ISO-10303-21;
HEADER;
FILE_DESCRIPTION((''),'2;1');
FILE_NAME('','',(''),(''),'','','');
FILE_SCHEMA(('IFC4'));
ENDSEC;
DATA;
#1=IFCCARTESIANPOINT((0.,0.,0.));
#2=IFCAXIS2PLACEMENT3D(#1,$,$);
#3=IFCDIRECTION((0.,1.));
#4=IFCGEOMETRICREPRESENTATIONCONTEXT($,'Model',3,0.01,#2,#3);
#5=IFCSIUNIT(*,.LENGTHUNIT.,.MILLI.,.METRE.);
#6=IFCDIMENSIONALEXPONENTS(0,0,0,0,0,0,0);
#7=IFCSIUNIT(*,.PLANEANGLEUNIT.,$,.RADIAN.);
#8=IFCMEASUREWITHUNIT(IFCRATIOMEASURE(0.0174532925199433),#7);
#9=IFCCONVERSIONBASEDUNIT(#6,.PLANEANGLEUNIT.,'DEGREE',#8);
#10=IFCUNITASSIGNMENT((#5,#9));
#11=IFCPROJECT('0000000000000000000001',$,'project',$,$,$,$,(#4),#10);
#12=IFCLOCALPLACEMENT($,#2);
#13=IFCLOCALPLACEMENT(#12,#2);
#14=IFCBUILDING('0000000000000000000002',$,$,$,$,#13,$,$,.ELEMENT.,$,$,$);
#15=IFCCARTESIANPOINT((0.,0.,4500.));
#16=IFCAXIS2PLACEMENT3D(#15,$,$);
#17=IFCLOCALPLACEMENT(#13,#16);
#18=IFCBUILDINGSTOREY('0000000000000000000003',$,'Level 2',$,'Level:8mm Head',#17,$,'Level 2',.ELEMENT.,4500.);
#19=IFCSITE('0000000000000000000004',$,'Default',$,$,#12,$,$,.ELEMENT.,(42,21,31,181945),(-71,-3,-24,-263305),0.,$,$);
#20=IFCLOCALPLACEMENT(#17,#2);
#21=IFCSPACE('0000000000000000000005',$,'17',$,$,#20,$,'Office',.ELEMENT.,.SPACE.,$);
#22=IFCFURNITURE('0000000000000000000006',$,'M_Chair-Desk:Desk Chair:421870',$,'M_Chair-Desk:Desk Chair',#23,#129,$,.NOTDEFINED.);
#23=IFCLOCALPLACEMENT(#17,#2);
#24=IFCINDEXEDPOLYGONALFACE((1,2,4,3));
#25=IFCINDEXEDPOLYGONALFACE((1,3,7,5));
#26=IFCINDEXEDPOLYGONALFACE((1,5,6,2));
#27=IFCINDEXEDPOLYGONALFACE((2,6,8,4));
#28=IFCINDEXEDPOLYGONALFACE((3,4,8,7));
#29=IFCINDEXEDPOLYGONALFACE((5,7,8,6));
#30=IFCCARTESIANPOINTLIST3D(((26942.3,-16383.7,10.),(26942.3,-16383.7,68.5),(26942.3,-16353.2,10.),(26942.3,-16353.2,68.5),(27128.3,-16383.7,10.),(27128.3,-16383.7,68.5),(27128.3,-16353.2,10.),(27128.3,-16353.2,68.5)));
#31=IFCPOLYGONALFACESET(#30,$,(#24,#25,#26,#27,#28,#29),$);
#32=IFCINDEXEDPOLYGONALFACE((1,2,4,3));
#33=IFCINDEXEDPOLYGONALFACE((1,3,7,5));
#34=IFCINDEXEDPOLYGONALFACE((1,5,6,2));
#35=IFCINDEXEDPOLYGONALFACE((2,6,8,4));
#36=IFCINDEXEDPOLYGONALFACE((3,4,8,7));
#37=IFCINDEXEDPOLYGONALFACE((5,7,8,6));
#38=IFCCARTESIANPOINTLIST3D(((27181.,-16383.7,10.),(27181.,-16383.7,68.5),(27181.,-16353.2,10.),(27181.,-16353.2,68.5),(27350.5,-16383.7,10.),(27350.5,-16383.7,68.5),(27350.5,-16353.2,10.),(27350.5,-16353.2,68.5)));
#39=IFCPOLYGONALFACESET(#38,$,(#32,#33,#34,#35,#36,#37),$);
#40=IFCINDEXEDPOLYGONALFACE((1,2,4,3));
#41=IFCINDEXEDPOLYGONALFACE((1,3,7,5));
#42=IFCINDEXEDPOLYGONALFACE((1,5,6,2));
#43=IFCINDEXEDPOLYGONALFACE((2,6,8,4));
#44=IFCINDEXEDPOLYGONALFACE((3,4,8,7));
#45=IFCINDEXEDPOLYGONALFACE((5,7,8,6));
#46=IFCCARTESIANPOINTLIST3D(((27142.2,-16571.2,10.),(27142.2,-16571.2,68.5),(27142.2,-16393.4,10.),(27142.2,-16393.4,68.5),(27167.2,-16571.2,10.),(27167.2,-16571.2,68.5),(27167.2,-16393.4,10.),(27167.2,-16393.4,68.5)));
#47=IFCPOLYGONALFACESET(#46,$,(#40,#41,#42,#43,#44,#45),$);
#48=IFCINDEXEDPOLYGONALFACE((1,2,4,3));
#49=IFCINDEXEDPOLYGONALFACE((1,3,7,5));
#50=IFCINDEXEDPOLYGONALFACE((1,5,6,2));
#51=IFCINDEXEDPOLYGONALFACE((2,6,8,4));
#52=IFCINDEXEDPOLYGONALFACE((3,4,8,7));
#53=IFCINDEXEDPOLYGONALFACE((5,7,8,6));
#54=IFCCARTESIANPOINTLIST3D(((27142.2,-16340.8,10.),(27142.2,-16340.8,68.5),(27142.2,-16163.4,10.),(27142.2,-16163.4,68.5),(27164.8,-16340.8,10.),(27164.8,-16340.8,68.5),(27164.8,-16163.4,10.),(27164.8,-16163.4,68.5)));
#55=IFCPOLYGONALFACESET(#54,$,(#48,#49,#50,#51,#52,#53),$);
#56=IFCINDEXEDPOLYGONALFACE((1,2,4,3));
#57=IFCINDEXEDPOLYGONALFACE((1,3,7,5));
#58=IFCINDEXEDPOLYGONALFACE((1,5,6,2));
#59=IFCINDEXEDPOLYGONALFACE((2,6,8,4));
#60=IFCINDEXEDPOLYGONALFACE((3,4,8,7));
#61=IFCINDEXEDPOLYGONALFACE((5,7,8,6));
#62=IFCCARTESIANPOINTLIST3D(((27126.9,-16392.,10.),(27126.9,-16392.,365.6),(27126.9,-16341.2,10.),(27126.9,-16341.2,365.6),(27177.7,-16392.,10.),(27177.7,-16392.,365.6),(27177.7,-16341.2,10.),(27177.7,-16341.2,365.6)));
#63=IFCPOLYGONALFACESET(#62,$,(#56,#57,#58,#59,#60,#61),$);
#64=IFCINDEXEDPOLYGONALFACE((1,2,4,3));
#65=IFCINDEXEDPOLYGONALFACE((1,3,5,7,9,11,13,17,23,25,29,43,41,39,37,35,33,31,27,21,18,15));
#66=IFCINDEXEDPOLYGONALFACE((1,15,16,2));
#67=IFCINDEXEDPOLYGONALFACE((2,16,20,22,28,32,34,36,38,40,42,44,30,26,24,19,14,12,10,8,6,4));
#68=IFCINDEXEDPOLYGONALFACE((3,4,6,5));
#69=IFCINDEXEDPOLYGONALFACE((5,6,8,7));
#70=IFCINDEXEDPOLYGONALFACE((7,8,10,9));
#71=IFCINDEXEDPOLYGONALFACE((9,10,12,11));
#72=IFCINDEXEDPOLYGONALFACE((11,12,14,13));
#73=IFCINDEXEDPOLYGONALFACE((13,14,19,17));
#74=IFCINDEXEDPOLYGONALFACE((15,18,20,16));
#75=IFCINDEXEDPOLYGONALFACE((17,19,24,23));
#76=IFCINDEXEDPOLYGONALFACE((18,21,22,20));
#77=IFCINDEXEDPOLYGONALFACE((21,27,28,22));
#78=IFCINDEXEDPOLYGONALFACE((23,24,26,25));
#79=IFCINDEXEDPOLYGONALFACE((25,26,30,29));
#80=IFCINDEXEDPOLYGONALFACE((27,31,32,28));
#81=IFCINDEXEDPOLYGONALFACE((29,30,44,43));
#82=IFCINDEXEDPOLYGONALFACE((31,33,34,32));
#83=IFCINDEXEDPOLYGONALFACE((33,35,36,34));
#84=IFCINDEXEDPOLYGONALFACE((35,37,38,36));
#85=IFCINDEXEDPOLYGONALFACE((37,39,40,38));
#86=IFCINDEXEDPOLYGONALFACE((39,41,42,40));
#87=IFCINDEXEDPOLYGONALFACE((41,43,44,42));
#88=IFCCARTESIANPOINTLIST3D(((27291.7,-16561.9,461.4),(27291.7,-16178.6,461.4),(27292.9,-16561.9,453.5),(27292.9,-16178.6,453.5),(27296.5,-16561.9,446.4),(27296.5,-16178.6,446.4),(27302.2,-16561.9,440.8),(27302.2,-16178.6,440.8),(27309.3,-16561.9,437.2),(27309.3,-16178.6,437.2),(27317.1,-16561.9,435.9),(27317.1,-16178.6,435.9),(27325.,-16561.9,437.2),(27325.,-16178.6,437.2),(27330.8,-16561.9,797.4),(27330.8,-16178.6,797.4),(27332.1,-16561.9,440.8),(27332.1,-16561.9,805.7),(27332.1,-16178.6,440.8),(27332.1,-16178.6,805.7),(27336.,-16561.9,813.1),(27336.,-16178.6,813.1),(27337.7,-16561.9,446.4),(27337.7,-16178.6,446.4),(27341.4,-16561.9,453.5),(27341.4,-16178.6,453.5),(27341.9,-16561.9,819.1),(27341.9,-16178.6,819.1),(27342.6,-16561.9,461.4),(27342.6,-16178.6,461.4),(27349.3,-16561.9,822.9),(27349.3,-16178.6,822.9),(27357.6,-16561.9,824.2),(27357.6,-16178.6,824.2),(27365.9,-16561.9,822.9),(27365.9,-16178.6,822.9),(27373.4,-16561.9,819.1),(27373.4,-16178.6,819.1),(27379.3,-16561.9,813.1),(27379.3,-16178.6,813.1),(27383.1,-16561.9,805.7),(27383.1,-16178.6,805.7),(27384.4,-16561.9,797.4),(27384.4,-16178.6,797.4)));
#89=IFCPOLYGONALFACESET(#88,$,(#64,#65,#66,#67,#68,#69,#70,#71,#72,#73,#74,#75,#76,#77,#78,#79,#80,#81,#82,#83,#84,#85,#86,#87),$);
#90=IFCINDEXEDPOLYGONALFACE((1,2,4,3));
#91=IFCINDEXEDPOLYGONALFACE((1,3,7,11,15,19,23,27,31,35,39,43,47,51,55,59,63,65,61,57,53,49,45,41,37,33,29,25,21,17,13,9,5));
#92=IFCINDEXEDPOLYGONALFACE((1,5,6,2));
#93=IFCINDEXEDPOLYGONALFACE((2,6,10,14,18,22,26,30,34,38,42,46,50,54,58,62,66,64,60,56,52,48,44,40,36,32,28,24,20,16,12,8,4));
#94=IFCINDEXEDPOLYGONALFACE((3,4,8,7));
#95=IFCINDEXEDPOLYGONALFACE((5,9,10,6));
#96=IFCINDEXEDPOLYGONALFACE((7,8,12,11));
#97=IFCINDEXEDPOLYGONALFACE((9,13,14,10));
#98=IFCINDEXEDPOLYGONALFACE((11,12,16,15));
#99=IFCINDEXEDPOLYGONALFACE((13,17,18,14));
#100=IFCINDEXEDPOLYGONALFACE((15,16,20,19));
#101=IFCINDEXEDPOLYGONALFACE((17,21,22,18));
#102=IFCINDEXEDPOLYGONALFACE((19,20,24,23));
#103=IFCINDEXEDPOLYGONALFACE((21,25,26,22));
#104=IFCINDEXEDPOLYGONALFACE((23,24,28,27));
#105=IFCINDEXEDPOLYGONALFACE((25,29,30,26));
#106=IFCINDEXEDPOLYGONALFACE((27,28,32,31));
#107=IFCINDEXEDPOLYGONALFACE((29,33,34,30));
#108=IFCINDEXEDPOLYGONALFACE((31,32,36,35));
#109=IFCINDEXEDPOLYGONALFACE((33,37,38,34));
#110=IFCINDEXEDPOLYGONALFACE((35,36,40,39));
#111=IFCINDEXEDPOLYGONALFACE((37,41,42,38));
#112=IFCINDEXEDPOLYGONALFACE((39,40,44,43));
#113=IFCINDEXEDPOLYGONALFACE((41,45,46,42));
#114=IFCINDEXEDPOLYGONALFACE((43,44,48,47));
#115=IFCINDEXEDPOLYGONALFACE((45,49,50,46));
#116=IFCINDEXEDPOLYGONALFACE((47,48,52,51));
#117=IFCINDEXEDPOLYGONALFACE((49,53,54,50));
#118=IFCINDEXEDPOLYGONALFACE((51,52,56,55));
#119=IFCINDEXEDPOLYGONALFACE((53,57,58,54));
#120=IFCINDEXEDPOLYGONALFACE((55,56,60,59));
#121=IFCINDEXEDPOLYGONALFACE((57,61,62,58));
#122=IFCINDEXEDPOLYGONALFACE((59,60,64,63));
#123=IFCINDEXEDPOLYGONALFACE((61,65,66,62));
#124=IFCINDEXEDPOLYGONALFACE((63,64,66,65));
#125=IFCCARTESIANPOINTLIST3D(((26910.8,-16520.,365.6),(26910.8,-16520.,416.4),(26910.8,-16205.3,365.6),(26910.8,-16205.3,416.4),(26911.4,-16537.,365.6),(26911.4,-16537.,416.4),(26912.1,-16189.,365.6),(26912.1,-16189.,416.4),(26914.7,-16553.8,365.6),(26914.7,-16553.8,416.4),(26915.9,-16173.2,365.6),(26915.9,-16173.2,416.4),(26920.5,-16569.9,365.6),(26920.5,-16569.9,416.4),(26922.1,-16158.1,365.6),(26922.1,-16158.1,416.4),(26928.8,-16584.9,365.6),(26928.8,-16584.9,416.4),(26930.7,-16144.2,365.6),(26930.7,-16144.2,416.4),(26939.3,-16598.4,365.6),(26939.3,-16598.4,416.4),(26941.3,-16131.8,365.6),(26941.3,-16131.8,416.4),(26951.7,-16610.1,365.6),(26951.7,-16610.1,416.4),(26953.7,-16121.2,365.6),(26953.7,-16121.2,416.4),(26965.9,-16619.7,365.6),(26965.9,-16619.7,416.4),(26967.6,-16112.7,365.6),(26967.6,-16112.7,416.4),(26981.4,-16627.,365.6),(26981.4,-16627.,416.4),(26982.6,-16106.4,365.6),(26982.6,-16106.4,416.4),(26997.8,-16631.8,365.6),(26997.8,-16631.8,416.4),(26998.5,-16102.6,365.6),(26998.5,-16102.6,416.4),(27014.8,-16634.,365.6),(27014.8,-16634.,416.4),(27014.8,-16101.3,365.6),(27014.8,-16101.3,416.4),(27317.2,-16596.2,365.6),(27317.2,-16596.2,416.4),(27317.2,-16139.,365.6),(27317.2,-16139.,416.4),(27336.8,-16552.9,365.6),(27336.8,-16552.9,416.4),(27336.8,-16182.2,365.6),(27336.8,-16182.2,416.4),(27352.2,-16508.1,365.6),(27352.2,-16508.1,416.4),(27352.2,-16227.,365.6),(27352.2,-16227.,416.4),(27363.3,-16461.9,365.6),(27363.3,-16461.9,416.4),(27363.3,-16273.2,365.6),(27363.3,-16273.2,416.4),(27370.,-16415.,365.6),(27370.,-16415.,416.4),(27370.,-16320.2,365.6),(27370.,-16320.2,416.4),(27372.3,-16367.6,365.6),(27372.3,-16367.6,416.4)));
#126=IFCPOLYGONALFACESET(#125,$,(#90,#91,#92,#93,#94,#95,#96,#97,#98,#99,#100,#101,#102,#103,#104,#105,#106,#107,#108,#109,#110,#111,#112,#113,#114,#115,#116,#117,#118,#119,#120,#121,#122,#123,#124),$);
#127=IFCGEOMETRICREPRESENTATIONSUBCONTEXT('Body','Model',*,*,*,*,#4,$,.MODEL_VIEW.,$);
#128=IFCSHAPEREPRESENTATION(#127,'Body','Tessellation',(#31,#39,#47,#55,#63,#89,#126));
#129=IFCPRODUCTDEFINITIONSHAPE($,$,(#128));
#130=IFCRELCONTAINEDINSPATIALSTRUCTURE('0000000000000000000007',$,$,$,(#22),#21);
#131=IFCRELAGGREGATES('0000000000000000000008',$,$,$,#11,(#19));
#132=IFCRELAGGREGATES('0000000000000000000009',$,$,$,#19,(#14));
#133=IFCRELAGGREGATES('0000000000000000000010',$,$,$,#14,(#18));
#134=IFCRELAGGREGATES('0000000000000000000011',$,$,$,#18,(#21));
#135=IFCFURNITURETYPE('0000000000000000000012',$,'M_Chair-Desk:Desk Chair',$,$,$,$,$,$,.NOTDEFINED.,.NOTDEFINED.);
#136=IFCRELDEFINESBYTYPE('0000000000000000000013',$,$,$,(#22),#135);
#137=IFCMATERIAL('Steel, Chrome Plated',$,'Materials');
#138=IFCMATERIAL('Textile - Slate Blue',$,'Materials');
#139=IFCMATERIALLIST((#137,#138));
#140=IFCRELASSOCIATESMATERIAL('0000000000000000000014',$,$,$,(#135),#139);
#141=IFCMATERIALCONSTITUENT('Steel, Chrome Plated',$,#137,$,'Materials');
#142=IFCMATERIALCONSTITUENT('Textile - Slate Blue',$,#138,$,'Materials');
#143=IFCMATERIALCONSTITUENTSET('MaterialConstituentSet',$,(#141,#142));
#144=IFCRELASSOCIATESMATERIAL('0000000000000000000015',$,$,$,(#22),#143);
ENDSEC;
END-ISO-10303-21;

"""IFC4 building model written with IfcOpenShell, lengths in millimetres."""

from ifc_helpers import new_model, entity, si_unit, converted_unit, direction, frame, origin, place, context, subcontext, project, spatial, indexed_curve, outline, extrude, source, transform, mapped, material, material_list, constituent, constituent_set, type_object, type_shapes, element, save


model = new_model("IFC4")

# Units and contexts
model_context = context("Model", 3, precision=0.01, world=origin(), true_north=direction((0.0, 1.0)))
body_context = subcontext(model_context, "Body", "Model", "MODEL_VIEW")
ifc_project = project(units=[si_unit("LENGTHUNIT", "METRE", prefix="MILLI"), converted_unit("PLANEANGLEUNIT", "DEGREE", entity("IfcRatioMeasure", 0.0174532925199433), si_unit("PLANEANGLEUNIT", "RADIAN"), dimensions=[0, 0, 0, 0, 0, 0, 0])], contexts=[model_context])

# Site, building, storey
site_placement = place(None, origin())
site = spatial("IfcSite", under=ifc_project, at=site_placement, Name="Default", CompositionType="ELEMENT", RefLatitude=(42, 21, 31, 181945), RefLongitude=(-71, -3, -24, -263305), RefElevation=0.0)
building_placement = place(site_placement, origin())
building = spatial("IfcBuilding", under=site, at=building_placement, CompositionType="ELEMENT")
storey_placement = place(building_placement, frame((0.0, 0.0, 4500.0)))
storey = spatial("IfcBuildingStorey", under=building, at=storey_placement, Name="Level 2", ObjectType="Level:8mm Head", LongName="Level 2", CompositionType="ELEMENT", Elevation=4500.0)

# Shared definitions
space_placement = place(storey_placement, origin())
space = spatial("IfcSpace", under=storey, at=space_placement, Name="17", LongName="Office", CompositionType="ELEMENT", PredefinedType="SPACE")

# Furniture
ifc_material_1 = material(Name="Steel, Chrome Plated", Category="Materials")
ifc_material_2 = material(Name="Textile - Slate Blue", Category="Materials")
ifc_material_list_1 = material_list([ifc_material_1, ifc_material_2])
furniture_type = type_object("IfcFurnitureType", Name="M_Chair-Desk:Desk Chair", AssemblyPlace="NOTDEFINED", PredefinedType="NOTDEFINED", material=ifc_material_list_1)
shared_shape_1 = source(origin(), body_context, "Body", "SweptSolid", [
    extrude(outline(indexed_curve([(-15.2, -93.0), (15.2, -93.0), (15.2, 93.0), (-15.2, 93.0), (-15.2, -93.0)], self_intersect=False)), frame((-0.9, 281.9, 0.0)), (0.0, 0.0, 1.0), 58.5),
    extrude(outline(indexed_curve([(-15.2, -84.7), (15.2, -84.7), (15.2, 84.7), (-15.2, 84.7), (-15.2, -84.7)], self_intersect=False)), frame((-0.9, 51.5, 0.0), z_axis=(0.0, 0.0, 1.0), x_axis=(-1.0, 0.0, 0.0)), (0.0, 0.0, 1.0), 58.5),
    extrude(outline(indexed_curve([(-12.5, -88.9), (12.5, -88.9), (12.5, 88.9), (-12.5, 88.9), (-12.5, -88.9)], self_intersect=False)), frame((-114.8, 162.5, 0.0), z_axis=(0.0, 0.0, 1.0), x_axis=(0.0, -1.0, 0.0)), (0.0, 0.0, 1.0), 58.5),
    extrude(outline(indexed_curve([(-88.7, -11.3), (88.7, -11.3), (88.7, 11.3), (-88.7, 11.3), (-88.7, -11.3)], self_intersect=False)), frame((115.5, 163.7, 0.0), z_axis=(0.0, 0.0, 1.0), x_axis=(-1.0, 0.0, 0.0)), (0.0, 0.0, 1.0), 58.5),
    extrude(outline(indexed_curve([(-25.4, -25.4), (25.4, -25.4), (25.4, 25.4), (-25.4, 25.4), (-25.4, -25.4)], self_intersect=False)), frame((0.9, 164.9, 0.0), z_axis=(0.0, 0.0, 1.0), x_axis=(-1.0, 0.0, 0.0)), (0.0, 0.0, 1.0), 355.6),
    extrude(outline(indexed_curve([(6.5, 168.0), (5.2, 176.3), (1.4, 183.8), (-4.5, 189.7), (-12.0, 193.5), (-20.2, 194.8), (-28.5, 193.5), (-36.0, 189.7), (-41.9, 183.8), (-45.7, 176.3), (-47.0, 168.0), (-5.2, -168.0), (-4.0, -175.9), (-0.4, -183.0), (5.3, -188.6), (12.4, -192.2), (20.2, -193.5), (28.1, -192.2), (35.2, -188.6), (40.9, -183.0), (44.5, -175.9), (45.7, -168.0), (6.5, 168.0)], self_intersect=False)), frame((-194.4, -20.2, 619.4), z_axis=(1.0, 0.0, 0.0), x_axis=(0.0, 1.0, 0.0)), (0.0, 0.0, 1.0), 383.3),
    extrude(outline(indexed_curve([(-98.9, -257.7), (205.9, -257.7), (230.7, -217.3), (251.6, -174.7), (268.3, -130.3), (280.8, -84.5), (288.9, -37.7), (292.6, 9.6), (291.7, 57.0), (286.4, 104.2), (276.7, 150.6), (262.6, 195.9), (-32.8, 270.8), (-49.1, 271.5), (-65.3, 269.7), (-81.1, 265.4), (-95.9, 258.6), (-109.5, 249.7), (-121.6, 238.7), (-131.8, 225.9), (-139.8, 211.7), (-145.6, 196.5), (-148.9, 180.5), (-187.9, -131.7), (-189.4, -148.8), (-188.3, -165.8), (-184.5, -182.5), (-178.1, -198.4), (-169.4, -213.1), (-158.5, -226.2), (-145.6, -237.5), (-131.2, -246.7), (-115.5, -253.5), (-98.9, -257.7)], self_intersect=False)), frame((1.6, 236.3, 355.6), z_axis=(0.0, 0.0, 1.0), x_axis=(0.124035, -0.992278, 0.0)), (0.0, 0.0, 1.0), 50.8),
])
type_shapes(furniture_type, [shared_shape_1])
ifc_constituent_1 = constituent(ifc_material_1, Name="Steel, Chrome Plated", Category="Materials")
ifc_constituent_2 = constituent(ifc_material_2, Name="Textile - Slate Blue", Category="Materials")
ifc_constituent_set_1 = constituent_set(constituents=[ifc_constituent_1, ifc_constituent_2], Name="MaterialConstituentSet")
furniture_1_placement = place(space_placement, frame((27317.2, -16367.6, 10.0), z_axis=(0.0, 0.0, 1.0), x_axis=(0.0, 1.0, 0.0)))
element("IfcFurniture", 1, at=furniture_1_placement, inside=space, type_object=furniture_type, material=ifc_constituent_set_1, Name="M_Chair-Desk:Desk Chair:421870", ObjectType="M_Chair-Desk:Desk Chair", PredefinedType="NOTDEFINED", context=body_context, shape_type="MappedRepresentation", body=[
    mapped(shared_shape_1, transform((0.0, 0.0, 0.0), scale=1.0)),
])

save(model, "model.ifc")
